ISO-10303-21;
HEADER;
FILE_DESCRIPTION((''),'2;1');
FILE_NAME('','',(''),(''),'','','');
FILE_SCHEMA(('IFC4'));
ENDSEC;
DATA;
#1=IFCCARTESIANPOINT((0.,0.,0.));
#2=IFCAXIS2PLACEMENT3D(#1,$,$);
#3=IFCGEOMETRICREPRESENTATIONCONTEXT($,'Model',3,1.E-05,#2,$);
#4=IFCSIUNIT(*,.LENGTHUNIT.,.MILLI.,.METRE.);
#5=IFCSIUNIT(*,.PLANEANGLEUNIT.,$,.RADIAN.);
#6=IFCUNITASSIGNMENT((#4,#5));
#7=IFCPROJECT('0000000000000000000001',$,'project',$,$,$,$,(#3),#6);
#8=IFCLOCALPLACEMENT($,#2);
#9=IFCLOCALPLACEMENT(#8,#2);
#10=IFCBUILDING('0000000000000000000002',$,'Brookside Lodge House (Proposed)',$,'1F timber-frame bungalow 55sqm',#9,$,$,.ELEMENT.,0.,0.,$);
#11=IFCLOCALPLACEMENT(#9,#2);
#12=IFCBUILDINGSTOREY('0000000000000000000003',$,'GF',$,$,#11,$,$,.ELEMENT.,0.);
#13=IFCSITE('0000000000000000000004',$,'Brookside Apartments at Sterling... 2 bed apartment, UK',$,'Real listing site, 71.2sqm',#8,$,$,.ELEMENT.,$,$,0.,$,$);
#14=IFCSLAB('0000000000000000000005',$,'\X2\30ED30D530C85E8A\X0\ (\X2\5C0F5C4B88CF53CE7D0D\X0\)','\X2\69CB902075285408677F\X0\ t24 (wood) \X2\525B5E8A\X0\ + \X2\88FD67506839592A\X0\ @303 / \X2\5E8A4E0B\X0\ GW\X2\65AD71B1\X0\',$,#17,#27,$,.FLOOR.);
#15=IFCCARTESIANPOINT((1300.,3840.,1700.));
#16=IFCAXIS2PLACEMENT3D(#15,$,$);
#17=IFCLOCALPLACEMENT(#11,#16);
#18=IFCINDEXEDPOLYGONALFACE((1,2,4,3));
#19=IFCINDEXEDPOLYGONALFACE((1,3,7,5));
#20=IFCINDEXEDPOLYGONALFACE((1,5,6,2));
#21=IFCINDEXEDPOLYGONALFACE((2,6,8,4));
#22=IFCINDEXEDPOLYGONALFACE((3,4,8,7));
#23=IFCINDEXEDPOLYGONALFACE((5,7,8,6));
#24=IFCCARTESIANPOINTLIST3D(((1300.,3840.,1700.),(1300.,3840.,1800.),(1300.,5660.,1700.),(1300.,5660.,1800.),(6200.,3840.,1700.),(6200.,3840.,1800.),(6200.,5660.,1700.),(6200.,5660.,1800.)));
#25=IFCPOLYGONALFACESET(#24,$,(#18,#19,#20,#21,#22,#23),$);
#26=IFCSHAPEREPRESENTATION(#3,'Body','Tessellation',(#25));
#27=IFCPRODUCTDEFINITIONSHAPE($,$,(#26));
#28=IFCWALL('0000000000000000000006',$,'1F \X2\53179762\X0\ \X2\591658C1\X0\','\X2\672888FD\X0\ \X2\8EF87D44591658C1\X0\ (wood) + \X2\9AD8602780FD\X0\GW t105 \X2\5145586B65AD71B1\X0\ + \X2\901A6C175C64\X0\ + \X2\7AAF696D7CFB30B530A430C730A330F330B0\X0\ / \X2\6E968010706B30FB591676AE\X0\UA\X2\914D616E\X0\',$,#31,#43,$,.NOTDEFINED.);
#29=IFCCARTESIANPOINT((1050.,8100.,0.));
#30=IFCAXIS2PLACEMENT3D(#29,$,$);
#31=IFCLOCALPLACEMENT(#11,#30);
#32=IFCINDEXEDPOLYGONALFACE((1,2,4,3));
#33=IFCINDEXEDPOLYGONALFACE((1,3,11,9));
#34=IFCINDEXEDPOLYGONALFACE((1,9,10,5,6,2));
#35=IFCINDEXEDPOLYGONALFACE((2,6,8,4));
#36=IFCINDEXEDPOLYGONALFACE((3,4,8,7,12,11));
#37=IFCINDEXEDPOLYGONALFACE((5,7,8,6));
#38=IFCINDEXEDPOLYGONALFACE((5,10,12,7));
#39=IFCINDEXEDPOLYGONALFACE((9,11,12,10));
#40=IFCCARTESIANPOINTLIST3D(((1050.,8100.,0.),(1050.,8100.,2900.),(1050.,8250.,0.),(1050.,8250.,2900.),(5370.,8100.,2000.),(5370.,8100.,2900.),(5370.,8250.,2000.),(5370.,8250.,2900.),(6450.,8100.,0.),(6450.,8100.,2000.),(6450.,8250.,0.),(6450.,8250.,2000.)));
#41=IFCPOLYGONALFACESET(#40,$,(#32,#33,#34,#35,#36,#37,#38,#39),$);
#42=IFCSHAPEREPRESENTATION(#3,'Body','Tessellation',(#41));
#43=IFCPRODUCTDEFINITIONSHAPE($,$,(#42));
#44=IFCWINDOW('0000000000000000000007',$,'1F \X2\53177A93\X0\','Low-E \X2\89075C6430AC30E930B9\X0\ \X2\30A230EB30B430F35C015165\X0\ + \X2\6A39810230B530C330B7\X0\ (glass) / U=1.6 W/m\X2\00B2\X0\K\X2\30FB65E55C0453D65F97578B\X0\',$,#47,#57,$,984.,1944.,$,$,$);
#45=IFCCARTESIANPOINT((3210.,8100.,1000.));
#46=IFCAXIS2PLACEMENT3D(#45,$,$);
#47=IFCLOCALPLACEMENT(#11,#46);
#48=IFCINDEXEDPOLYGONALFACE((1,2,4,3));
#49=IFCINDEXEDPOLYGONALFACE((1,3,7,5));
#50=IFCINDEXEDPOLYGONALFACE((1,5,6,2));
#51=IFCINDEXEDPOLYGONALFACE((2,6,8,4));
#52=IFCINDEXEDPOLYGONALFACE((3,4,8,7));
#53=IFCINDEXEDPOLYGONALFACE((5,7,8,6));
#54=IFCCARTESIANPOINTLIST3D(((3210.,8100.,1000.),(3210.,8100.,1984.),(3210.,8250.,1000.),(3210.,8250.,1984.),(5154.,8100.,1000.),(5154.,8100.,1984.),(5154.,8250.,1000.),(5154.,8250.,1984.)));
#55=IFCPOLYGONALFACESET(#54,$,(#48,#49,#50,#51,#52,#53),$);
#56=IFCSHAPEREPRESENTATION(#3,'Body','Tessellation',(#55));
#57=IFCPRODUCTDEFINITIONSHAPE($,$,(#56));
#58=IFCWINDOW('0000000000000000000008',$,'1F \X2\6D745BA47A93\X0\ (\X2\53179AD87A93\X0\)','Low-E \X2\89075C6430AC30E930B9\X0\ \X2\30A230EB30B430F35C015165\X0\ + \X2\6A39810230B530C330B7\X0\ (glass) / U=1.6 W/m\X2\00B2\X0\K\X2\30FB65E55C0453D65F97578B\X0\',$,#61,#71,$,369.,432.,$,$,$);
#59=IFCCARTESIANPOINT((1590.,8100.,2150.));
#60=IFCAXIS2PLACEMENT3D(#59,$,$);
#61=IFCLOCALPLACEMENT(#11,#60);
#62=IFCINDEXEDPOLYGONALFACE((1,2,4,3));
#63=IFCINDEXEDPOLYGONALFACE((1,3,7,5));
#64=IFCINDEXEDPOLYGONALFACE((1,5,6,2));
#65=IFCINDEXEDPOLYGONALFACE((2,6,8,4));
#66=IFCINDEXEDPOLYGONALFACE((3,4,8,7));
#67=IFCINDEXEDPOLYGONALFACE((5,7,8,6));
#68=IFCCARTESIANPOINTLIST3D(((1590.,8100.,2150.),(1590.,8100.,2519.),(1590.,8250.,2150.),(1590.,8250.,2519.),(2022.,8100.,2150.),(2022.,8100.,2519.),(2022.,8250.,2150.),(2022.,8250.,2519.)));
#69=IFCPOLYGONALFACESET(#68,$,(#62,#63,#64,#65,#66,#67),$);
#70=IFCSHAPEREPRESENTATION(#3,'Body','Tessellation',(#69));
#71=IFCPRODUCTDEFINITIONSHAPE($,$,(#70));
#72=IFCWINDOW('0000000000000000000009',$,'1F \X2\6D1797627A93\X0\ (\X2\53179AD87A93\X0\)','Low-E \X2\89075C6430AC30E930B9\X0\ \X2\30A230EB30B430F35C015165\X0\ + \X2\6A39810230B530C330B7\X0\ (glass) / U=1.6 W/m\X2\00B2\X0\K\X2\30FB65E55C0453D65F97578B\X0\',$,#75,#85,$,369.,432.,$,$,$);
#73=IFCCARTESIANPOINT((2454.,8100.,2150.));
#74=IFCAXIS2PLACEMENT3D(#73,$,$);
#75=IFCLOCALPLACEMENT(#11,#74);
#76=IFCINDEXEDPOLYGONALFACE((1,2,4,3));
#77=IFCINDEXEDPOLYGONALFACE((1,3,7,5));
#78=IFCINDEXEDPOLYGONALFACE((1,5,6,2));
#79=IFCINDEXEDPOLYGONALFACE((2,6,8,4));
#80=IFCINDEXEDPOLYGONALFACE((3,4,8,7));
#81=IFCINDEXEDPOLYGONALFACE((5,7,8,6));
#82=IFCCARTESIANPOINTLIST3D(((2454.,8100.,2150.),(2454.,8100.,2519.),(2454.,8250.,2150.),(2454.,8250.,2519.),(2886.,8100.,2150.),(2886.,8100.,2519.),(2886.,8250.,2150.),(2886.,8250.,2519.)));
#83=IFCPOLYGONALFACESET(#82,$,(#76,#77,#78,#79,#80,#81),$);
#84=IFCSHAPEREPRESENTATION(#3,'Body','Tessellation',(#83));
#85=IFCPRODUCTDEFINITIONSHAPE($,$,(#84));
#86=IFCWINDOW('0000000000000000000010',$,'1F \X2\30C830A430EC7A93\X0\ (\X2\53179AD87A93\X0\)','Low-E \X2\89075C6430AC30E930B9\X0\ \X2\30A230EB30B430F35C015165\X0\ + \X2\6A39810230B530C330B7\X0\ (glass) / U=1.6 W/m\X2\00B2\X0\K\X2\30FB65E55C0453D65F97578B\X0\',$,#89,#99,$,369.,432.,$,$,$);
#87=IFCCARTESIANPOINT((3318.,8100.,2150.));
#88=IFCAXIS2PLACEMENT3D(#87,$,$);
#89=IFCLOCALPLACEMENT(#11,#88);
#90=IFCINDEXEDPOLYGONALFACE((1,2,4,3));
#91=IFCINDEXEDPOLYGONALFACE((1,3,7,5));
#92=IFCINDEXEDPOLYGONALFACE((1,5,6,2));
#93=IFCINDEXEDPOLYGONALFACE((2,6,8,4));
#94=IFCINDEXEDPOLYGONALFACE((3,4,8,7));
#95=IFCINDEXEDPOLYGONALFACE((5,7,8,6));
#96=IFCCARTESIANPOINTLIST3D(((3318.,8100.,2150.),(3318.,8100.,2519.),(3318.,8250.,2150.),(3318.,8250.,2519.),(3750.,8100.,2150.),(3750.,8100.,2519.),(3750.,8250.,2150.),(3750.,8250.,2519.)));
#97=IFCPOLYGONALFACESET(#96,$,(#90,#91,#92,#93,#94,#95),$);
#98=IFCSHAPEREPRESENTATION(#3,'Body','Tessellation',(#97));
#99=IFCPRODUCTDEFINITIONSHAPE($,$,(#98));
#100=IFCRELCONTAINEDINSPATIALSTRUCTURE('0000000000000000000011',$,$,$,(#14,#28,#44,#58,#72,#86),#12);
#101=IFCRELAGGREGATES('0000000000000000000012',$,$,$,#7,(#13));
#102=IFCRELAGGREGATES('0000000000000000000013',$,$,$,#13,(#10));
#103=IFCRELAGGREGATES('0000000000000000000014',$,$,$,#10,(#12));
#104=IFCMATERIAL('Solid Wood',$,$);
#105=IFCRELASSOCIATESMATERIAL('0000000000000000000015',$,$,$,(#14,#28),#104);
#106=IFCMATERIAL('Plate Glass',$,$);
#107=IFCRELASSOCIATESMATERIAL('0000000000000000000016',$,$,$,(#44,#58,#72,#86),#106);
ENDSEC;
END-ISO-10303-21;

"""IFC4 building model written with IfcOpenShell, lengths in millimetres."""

from ifc_helpers import new_model, si_unit, frame, frame_2d, origin, place, context, project, spatial, rectangle, extrude, material, element, fill, save


model = new_model("IFC4")

# Units and contexts
model_context = context("Model", 3, precision=1e-05, world=origin())
ifc_project = project(units=[si_unit("LENGTHUNIT", "METRE", prefix="MILLI"), si_unit("PLANEANGLEUNIT", "RADIAN")], contexts=[model_context])

# Site, building, storey
site_placement = place(None, origin())
site = spatial("IfcSite", under=ifc_project, at=site_placement, Name="Brookside Apartments at Sterling... 2 bed apartment, UK", ObjectType="Real listing site, 71.2sqm", CompositionType="ELEMENT", RefElevation=0.0)
building_placement = place(site_placement, origin())
building = spatial("IfcBuilding", under=site, at=building_placement, Name="Brookside Lodge House (Proposed)", ObjectType="1F timber-frame bungalow 55sqm", CompositionType="ELEMENT", ElevationOfRefHeight=0.0, ElevationOfTerrain=0.0)
storey_placement = place(building_placement, origin())
storey = spatial("IfcBuildingStorey", under=building, at=storey_placement, Name="GF", CompositionType="ELEMENT", Elevation=0.0)

# Slab
ifc_material_1 = material(Name="Solid Wood")
slab_placement = place(storey_placement, frame((1300.0, 3840.0, 1700.0)))
element("IfcSlab", 1, at=slab_placement, inside=storey, material=ifc_material_1, Name="ロフト床 (小屋裏収納)", Description="構造用合板 t24 (wood) 剛床 + 製材根太 @303 / 床下 GW断熱", PredefinedType="FLOOR", context=model_context, shape_type="SweptSolid", body=[
    extrude(rectangle(XDim=4900.0, YDim=1820.0, at=frame_2d((2450.0, 910.0))), frame((1300.0, 3840.0, 1700.0)), (0.0, 0.0, 1.0), 100.0),
])

# Wall, openings, windows
wall_1_placement = place(storey_placement, frame((1050.0, 8100.0, 0.0)))
wall_1 = element("IfcWall", 2, at=wall_1_placement, inside=storey, material=ifc_material_1, Name="1F 北面 外壁", Description="木製 軸組外壁 (wood) + 高性能GW t105 充填断熱 + 通気層 + 窯業系サイディング / 準耐火・外皮UA配慮", PredefinedType="NOTDEFINED", context=model_context, shape_type="SweptSolid", body=[
    extrude(rectangle(XDim=5400.0, YDim=150.0, at=frame_2d((2700.0, 75.0))), frame((1050.0, 8100.0, 0.0)), (0.0, 0.0, 1.0), 2900.0),
])
opening_1_placement = place(storey_placement, frame((3210.0, 8100.0, 1000.0)))
opening_1 = element("IfcOpeningElement", 3, at=opening_1_placement, cuts=wall_1, PredefinedType="NOTDEFINED", context=model_context, shape_type="SweptSolid", body=[
    extrude(rectangle(XDim=1944.0, YDim=150.0, at=frame_2d((972.0, 75.0))), frame((3210.0, 8100.0, 1000.0)), (0.0, 0.0, 1.0), 984.0),
])
opening_2_placement = place(storey_placement, frame((1590.0, 8100.0, 2150.0)))
opening_2 = element("IfcOpeningElement", 4, at=opening_2_placement, cuts=wall_1, PredefinedType="NOTDEFINED", context=model_context, shape_type="SweptSolid", body=[
    extrude(rectangle(XDim=432.0, YDim=150.0, at=frame_2d((216.0, 75.0))), frame((1590.0, 8100.0, 2150.0)), (0.0, 0.0, 1.0), 369.0),
])
opening_3_placement = place(storey_placement, frame((2454.0, 8100.0, 2150.0)))
opening_3 = element("IfcOpeningElement", 5, at=opening_3_placement, cuts=wall_1, PredefinedType="NOTDEFINED", context=model_context, shape_type="SweptSolid", body=[
    extrude(rectangle(XDim=432.0, YDim=150.0, at=frame_2d((216.0, 75.0))), frame((2454.0, 8100.0, 2150.0)), (0.0, 0.0, 1.0), 369.0),
])
opening_4_placement = place(storey_placement, frame((3318.0, 8100.0, 2150.0)))
opening_4 = element("IfcOpeningElement", 6, at=opening_4_placement, cuts=wall_1, PredefinedType="NOTDEFINED", context=model_context, shape_type="SweptSolid", body=[
    extrude(rectangle(XDim=432.0, YDim=150.0, at=frame_2d((216.0, 75.0))), frame((3318.0, 8100.0, 2150.0)), (0.0, 0.0, 1.0), 369.0),
])
ifc_material_2 = material(Name="Plate Glass")
window_1_placement = place(storey_placement, frame((3210.0, 8100.0, 1000.0)))
window_1 = element("IfcWindow", 7, at=window_1_placement, inside=storey, material=ifc_material_2, Name="1F 北窓", Description="Low-E 複層ガラス アルゴン封入 + 樹脂サッシ (glass) / U=1.6 W/m²K・日射取得型", OverallHeight=984.0, OverallWidth=1944.0, context=model_context, shape_type="SweptSolid", body=[
    extrude(rectangle(XDim=1944.0, YDim=150.0, at=frame_2d((972.0, 75.0))), frame((3210.0, 8100.0, 1000.0)), (0.0, 0.0, 1.0), 984.0),
])
fill(opening_1, window_1)
window_2_placement = place(storey_placement, frame((1590.0, 8100.0, 2150.0)))
window_2 = element("IfcWindow", 8, at=window_2_placement, inside=storey, material=ifc_material_2, Name="1F 浴室窓 (北高窓)", Description="Low-E 複層ガラス アルゴン封入 + 樹脂サッシ (glass) / U=1.6 W/m²K・日射取得型", OverallHeight=369.0, OverallWidth=432.0, context=model_context, shape_type="SweptSolid", body=[
    extrude(rectangle(XDim=432.0, YDim=150.0, at=frame_2d((216.0, 75.0))), frame((1590.0, 8100.0, 2150.0)), (0.0, 0.0, 1.0), 369.0),
])
fill(opening_2, window_2)
window_3_placement = place(storey_placement, frame((2454.0, 8100.0, 2150.0)))
window_3 = element("IfcWindow", 9, at=window_3_placement, inside=storey, material=ifc_material_2, Name="1F 洗面窓 (北高窓)", Description="Low-E 複層ガラス アルゴン封入 + 樹脂サッシ (glass) / U=1.6 W/m²K・日射取得型", OverallHeight=369.0, OverallWidth=432.0, context=model_context, shape_type="SweptSolid", body=[
    extrude(rectangle(XDim=432.0, YDim=150.0, at=frame_2d((216.0, 75.0))), frame((2454.0, 8100.0, 2150.0)), (0.0, 0.0, 1.0), 369.0),
])
fill(opening_3, window_3)
window_4_placement = place(storey_placement, frame((3318.0, 8100.0, 2150.0)))
window_4 = element("IfcWindow", 10, at=window_4_placement, inside=storey, material=ifc_material_2, Name="1F トイレ窓 (北高窓)", Description="Low-E 複層ガラス アルゴン封入 + 樹脂サッシ (glass) / U=1.6 W/m²K・日射取得型", OverallHeight=369.0, OverallWidth=432.0, context=model_context, shape_type="SweptSolid", body=[
    extrude(rectangle(XDim=432.0, YDim=150.0, at=frame_2d((216.0, 75.0))), frame((3318.0, 8100.0, 2150.0)), (0.0, 0.0, 1.0), 369.0),
])
fill(opening_4, window_4)

save(model, "model.ifc")
